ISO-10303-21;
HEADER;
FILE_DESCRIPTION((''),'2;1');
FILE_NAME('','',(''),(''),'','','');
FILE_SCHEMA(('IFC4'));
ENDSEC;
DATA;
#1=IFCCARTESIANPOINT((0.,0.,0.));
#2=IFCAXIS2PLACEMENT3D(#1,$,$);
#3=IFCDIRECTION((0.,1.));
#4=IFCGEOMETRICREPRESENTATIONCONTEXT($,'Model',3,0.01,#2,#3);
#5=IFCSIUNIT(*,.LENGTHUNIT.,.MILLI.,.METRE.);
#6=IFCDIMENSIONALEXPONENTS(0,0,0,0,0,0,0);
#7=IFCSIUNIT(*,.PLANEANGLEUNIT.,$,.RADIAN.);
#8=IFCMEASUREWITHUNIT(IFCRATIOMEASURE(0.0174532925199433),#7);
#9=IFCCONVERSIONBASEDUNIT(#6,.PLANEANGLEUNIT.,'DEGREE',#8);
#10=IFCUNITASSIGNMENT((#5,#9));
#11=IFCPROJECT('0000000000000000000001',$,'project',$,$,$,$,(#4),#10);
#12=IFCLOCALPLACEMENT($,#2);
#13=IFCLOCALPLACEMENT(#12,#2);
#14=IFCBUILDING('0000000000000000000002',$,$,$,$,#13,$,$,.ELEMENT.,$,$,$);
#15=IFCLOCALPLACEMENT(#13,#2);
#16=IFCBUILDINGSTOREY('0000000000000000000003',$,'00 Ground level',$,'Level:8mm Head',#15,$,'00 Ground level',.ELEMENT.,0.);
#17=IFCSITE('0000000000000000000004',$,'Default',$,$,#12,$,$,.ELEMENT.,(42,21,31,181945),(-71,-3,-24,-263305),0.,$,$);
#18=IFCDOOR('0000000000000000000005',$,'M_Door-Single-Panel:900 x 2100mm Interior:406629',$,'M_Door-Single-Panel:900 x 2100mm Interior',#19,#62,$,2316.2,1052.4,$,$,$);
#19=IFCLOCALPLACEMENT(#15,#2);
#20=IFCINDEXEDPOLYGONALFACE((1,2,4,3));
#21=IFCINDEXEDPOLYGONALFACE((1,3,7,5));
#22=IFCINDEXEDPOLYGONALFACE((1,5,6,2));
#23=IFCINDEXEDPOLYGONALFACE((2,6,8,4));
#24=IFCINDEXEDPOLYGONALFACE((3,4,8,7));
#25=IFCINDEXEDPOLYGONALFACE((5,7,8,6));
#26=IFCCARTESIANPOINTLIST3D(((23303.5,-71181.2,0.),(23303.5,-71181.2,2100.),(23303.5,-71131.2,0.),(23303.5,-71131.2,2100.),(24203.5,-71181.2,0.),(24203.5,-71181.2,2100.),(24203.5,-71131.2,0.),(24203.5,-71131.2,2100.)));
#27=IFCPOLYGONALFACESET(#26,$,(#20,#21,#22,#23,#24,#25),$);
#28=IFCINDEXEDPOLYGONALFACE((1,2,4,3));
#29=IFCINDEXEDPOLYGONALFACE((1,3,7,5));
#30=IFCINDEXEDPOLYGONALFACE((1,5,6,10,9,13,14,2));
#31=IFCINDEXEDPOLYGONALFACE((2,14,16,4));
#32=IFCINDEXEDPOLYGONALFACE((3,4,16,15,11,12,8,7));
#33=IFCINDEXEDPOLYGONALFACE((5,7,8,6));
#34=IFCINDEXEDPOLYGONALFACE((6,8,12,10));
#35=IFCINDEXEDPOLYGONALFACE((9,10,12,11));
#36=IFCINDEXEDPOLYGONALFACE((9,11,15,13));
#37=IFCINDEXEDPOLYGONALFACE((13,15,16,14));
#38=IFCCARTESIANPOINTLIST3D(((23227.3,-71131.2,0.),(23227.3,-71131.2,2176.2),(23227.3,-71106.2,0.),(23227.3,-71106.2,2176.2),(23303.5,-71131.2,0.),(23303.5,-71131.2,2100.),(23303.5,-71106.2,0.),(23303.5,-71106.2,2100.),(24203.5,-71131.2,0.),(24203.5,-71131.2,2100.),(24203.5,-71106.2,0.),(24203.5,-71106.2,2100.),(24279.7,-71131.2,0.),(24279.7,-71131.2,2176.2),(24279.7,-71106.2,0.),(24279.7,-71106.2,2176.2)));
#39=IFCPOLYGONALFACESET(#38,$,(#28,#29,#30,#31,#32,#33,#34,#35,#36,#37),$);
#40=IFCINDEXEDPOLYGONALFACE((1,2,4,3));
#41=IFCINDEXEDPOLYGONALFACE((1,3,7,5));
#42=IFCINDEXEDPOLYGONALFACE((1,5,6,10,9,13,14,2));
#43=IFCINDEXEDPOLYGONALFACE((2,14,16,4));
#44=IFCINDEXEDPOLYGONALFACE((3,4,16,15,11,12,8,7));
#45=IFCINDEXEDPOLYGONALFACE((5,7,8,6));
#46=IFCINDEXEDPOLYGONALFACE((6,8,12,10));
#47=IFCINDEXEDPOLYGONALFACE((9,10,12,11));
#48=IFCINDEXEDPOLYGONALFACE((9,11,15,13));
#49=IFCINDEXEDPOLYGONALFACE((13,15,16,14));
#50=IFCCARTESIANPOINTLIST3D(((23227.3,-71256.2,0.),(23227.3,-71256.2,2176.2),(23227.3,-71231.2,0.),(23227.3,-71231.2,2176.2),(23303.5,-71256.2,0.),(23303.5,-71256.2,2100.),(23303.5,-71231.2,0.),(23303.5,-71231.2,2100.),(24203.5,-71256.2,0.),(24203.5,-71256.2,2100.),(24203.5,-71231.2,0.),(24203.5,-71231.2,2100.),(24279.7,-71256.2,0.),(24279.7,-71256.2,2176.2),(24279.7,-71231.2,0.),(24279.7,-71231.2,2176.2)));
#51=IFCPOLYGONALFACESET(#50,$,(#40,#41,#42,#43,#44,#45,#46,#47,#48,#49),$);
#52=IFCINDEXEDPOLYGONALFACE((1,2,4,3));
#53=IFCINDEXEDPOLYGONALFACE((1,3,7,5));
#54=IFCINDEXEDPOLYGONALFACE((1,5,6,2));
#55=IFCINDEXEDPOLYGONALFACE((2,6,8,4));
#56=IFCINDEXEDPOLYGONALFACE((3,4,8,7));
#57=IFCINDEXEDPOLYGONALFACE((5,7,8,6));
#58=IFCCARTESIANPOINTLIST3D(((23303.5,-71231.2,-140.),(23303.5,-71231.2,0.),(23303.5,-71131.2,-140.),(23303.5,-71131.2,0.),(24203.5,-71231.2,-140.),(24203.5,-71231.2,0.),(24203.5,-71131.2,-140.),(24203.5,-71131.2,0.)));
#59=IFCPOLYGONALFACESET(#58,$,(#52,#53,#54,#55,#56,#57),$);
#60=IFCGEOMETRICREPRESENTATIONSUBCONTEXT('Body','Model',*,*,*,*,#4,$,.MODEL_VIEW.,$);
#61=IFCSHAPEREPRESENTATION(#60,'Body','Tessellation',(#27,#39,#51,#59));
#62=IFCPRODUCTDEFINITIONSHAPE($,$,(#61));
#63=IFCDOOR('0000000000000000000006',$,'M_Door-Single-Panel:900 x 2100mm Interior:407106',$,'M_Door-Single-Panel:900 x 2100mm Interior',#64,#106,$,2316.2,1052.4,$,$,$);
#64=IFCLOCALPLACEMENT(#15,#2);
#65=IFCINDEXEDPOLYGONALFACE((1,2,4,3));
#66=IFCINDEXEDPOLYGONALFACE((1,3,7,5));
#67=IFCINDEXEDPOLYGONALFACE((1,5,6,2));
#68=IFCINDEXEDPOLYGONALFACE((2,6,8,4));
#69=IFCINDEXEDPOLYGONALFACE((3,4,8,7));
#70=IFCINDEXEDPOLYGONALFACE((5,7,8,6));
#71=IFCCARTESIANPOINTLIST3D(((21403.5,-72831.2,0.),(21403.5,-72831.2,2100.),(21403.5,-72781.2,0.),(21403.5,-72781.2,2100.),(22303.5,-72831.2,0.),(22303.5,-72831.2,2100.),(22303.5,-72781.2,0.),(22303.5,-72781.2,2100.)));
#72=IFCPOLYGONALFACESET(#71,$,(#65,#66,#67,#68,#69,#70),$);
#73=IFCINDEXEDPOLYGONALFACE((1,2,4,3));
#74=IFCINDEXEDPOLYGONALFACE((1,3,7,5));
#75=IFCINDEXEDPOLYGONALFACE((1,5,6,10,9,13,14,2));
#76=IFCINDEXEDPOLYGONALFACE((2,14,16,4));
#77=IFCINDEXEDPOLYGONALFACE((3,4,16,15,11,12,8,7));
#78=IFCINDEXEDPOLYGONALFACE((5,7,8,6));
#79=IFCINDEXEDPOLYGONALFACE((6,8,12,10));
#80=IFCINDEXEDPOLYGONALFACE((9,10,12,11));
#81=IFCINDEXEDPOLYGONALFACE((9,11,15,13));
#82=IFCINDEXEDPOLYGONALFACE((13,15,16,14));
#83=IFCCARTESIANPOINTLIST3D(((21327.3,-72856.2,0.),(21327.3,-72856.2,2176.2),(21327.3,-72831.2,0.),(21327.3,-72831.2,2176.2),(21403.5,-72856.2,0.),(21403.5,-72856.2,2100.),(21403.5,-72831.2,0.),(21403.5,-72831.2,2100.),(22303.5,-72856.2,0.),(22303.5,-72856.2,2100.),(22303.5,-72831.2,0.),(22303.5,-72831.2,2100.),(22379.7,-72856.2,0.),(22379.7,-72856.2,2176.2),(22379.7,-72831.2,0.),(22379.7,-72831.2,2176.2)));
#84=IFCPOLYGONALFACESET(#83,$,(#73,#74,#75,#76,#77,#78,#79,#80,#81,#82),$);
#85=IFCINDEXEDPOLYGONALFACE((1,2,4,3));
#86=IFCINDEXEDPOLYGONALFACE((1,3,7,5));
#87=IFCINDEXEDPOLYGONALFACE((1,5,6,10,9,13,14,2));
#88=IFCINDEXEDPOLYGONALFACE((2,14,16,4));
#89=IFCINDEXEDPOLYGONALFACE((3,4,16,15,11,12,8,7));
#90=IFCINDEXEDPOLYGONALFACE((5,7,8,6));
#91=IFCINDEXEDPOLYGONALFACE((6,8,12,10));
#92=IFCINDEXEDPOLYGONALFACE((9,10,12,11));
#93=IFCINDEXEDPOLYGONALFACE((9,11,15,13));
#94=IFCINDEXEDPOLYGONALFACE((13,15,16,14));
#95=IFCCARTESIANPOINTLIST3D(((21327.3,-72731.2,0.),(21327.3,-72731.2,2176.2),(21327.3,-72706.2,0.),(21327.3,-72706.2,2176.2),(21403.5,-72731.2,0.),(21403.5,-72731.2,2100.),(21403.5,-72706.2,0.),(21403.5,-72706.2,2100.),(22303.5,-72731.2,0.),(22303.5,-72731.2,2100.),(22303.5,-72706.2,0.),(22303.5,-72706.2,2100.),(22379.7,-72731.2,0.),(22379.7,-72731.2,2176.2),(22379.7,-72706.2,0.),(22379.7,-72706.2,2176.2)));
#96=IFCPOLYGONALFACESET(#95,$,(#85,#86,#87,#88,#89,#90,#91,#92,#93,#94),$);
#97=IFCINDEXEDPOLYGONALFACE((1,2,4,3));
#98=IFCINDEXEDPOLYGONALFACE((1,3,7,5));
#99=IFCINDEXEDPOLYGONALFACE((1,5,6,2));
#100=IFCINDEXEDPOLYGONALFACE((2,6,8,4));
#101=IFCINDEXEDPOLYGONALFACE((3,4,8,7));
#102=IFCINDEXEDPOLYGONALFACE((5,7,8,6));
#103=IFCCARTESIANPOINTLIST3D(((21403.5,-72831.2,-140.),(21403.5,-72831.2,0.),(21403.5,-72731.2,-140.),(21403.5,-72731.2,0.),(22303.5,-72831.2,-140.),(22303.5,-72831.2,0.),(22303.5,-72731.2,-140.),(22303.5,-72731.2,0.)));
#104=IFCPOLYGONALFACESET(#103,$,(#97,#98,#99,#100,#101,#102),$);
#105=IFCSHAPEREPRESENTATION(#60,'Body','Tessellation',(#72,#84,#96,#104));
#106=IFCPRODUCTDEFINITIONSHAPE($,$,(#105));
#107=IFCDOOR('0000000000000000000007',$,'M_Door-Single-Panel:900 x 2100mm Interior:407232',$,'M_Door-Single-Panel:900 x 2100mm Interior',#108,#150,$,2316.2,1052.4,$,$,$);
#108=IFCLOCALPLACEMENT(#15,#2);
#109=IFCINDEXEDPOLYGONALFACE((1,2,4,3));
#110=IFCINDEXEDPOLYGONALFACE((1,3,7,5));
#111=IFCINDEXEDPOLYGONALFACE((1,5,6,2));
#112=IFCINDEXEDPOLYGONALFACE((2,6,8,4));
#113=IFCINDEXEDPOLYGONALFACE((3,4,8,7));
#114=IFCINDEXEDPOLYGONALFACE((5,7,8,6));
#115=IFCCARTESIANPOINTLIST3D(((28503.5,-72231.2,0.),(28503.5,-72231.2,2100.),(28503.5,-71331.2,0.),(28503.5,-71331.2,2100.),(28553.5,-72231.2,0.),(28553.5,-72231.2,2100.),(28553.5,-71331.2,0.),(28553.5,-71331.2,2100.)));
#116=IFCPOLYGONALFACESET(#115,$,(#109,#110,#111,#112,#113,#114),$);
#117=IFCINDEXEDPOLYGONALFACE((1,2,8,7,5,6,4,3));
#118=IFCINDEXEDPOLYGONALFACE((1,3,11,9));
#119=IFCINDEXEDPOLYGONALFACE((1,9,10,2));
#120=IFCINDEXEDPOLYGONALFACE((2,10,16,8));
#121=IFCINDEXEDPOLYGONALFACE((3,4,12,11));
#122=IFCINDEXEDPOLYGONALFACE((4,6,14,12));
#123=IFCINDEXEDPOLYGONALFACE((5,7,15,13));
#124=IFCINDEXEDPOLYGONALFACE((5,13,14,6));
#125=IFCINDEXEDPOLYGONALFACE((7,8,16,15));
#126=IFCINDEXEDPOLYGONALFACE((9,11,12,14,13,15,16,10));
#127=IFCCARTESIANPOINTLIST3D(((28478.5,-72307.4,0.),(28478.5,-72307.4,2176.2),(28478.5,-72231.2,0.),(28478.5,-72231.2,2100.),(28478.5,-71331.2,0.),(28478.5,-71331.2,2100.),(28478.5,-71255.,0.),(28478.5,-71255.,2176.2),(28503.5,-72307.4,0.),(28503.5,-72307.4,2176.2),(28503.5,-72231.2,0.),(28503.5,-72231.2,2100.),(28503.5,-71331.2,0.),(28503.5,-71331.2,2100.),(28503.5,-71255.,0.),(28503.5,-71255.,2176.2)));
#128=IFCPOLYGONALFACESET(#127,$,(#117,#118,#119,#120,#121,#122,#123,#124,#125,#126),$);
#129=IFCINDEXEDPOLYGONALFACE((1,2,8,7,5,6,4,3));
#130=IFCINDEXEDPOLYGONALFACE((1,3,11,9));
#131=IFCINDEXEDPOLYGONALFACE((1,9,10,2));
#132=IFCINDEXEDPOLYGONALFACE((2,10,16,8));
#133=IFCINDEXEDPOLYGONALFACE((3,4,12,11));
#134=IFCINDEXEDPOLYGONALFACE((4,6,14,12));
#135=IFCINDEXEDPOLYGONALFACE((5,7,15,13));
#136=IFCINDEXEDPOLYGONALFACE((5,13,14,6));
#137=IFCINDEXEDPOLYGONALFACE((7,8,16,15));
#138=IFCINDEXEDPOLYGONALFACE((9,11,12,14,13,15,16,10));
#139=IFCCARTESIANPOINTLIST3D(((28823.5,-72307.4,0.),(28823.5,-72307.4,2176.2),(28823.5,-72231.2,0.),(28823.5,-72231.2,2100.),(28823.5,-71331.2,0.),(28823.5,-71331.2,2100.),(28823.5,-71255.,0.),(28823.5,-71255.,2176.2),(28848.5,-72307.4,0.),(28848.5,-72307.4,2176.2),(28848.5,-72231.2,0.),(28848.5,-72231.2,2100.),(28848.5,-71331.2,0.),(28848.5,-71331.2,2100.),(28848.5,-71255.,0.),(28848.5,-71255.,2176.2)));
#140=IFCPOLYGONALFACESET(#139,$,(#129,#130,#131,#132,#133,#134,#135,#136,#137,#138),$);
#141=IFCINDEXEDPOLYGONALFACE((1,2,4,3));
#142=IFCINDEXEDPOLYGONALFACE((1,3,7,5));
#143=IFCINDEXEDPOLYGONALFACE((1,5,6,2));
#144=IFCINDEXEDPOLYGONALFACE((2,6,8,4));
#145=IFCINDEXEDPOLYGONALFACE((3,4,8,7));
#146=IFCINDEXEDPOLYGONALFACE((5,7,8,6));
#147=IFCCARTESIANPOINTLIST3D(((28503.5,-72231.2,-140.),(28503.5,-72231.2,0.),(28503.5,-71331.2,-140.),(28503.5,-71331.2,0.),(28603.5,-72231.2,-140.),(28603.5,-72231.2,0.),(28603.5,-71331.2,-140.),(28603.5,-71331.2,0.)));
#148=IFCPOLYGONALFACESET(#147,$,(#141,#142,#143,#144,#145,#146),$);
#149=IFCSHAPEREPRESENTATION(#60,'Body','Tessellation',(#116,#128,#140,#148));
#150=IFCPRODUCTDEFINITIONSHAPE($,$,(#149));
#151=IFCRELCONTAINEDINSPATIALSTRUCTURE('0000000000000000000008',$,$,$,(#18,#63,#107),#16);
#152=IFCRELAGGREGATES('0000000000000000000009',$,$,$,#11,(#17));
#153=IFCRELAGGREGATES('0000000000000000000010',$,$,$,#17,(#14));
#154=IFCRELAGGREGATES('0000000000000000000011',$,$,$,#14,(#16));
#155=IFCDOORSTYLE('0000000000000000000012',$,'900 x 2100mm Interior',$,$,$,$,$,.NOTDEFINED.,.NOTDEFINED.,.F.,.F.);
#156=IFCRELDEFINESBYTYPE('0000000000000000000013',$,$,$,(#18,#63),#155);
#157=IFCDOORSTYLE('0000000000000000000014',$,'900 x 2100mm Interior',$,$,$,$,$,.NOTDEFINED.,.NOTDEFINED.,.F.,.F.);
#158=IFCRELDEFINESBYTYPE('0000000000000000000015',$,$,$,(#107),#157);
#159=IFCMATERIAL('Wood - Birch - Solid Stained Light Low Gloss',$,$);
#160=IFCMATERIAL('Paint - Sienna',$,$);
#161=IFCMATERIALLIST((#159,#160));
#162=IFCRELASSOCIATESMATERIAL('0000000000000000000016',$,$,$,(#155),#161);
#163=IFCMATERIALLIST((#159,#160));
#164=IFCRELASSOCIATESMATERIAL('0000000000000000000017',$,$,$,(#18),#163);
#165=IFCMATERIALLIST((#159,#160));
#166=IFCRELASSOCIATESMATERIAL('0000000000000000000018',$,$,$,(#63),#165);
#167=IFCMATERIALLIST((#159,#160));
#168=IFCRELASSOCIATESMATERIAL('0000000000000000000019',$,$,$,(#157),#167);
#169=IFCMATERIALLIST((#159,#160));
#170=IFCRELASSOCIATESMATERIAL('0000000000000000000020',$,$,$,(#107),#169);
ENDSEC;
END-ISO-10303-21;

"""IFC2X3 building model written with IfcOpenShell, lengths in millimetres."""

from ifc_helpers import new_model, entity, si_unit, converted_unit, direction, frame, frame_2d, origin, origin_2d_with_axis, place, context, subcontext, project, spatial, polyline, rectangle, outline, extrude, source, transform, mapped, material, material_list, type_object, type_shapes, element, save


model = new_model("IFC2X3")

# Units and contexts
model_context = context("Model", 3, precision=0.01, world=origin(), true_north=direction((0.0, 1.0)))
body_context = subcontext(model_context, "Body", "Model", "MODEL_VIEW")
ifc_project = project(units=[si_unit("LENGTHUNIT", "METRE", prefix="MILLI"), converted_unit("PLANEANGLEUNIT", "DEGREE", entity("IfcRatioMeasure", 0.0174532925199433), si_unit("PLANEANGLEUNIT", "RADIAN"), dimensions=[0, 0, 0, 0, 0, 0, 0])], contexts=[model_context])

# Site, building, storey
site_placement = place(None, origin())
site = spatial("IfcSite", under=ifc_project, at=site_placement, Name="Default", CompositionType="ELEMENT", RefLatitude=(42, 21, 31, 181945), RefLongitude=(-71, -3, -24, -263305), RefElevation=0.0)
building_placement = place(site_placement, origin())
building = spatial("IfcBuilding", under=site, at=building_placement, CompositionType="ELEMENT")
storey_placement = place(building_placement, origin())
storey = spatial("IfcBuildingStorey", under=building, at=storey_placement, Name="00 Ground level", ObjectType="Level:8mm Head", LongName="00 Ground level", CompositionType="ELEMENT", Elevation=0.0)

# Doors
ifc_material_1 = material(Name="Wood - Birch - Solid Stained Light Low Gloss")
ifc_material_2 = material(Name="Paint - Sienna")
ifc_material_list_1 = material_list([ifc_material_1, ifc_material_2])
ifc_material_list_2 = material_list([ifc_material_1, ifc_material_2])
door_style_1 = type_object("IfcDoorStyle", Name="900 x 2100mm Interior", ConstructionType="NOTDEFINED", OperationType="NOTDEFINED", ParameterTakesPrecedence=False, Sizeable=False, material=ifc_material_list_2)
shared_shape_1 = source(origin(), body_context, "Body", "SweptSolid", [
    extrude(rectangle(XDim=50.0, YDim=900.0, at=frame_2d((0.0, 0.0), x_axis=(1.0, 0.0))), frame((450.0, 75.0, 140.0), z_axis=(0.0, 0.0, 1.0), x_axis=(0.0, 1.0, 0.0)), (0.0, 0.0, 1.0), 2100.0),
    extrude(outline(polyline([(-526.2, -1107.2), (526.2, -1107.2), (526.2, 1069.0), (450.0, 1069.0), (450.0, -1031.0), (-450.0, -1031.0), (-450.0, 1069.0), (-526.2, 1069.0), (-526.2, -1107.2)])), frame((450.0, 100.0, 1209.0), z_axis=(0.0, 1.0, 0.0), x_axis=(1.0, 0.0, 0.0)), (0.0, 0.0, 1.0), 25.0),
    extrude(outline(polyline([(-1107.2, -526.2), (1069.0, -526.2), (1069.0, -450.0), (-1031.0, -450.0), (-1031.0, 450.0), (1069.0, 450.0), (1069.0, 526.2), (-1107.2, 526.2), (-1107.2, -526.2)])), frame((450.0, -25.0, 1209.0), z_axis=(0.0, 1.0, 0.0), x_axis=(0.0, 0.0, -1.0)), (0.0, 0.0, 1.0), 25.0),
    extrude(rectangle(XDim=900.0, YDim=100.0, at=origin_2d_with_axis()), frame((450.0, 50.0, 0.0), z_axis=(0.0, 0.0, 1.0), x_axis=(-1.0, 0.0, 0.0)), (0.0, 0.0, 1.0), 140.0),
])
type_shapes(door_style_1, [shared_shape_1])
door_1_placement = place(storey_placement, frame((23303.5, -71231.2, -140.0)))
element("IfcDoor", 1, at=door_1_placement, inside=storey, type_object=door_style_1, material=ifc_material_list_1, Name="M_Door-Single-Panel:900 x 2100mm Interior:406629", ObjectType="M_Door-Single-Panel:900 x 2100mm Interior", OverallHeight=2316.2, OverallWidth=1052.4, context=body_context, shape_type="MappedRepresentation", body=[
    mapped(shared_shape_1, transform((0.0, 0.0, 0.0), scale=1.0)),
])
ifc_material_list_3 = material_list([ifc_material_1, ifc_material_2])
door_2_placement = place(storey_placement, frame((22303.5, -72731.2, -140.0), z_axis=(0.0, 0.0, 1.0), x_axis=(-1.0, 0.0, 0.0)))
element("IfcDoor", 2, at=door_2_placement, inside=storey, type_object=door_style_1, material=ifc_material_list_3, Name="M_Door-Single-Panel:900 x 2100mm Interior:407106", ObjectType="M_Door-Single-Panel:900 x 2100mm Interior", OverallHeight=2316.2, OverallWidth=1052.4, context=body_context, shape_type="MappedRepresentation", body=[
    mapped(shared_shape_1, transform((0.0, 0.0, 0.0), scale=1.0)),
])
ifc_material_list_4 = material_list([ifc_material_1, ifc_material_2])
ifc_material_list_5 = material_list([ifc_material_1, ifc_material_2])
door_style_2 = type_object("IfcDoorStyle", Name="900 x 2100mm Interior", ConstructionType="NOTDEFINED", OperationType="NOTDEFINED", ParameterTakesPrecedence=False, Sizeable=False, material=ifc_material_list_5)
shared_shape_2 = source(origin(), body_context, "Body", "SweptSolid", [
    extrude(rectangle(XDim=50.0, YDim=900.0, at=origin_2d_with_axis()), frame((450.0, 295.0, 140.0), z_axis=(0.0, 0.0, 1.0), x_axis=(0.0, 1.0, 0.0)), (0.0, 0.0, 1.0), 2100.0),
    extrude(outline(polyline([(-526.2, -1107.2), (526.2, -1107.2), (526.2, 1069.0), (450.0, 1069.0), (450.0, -1031.0), (-450.0, -1031.0), (-450.0, 1069.0), (-526.2, 1069.0), (-526.2, -1107.2)])), frame((450.0, 320.0, 1209.0), z_axis=(0.0, 1.0, 0.0), x_axis=(1.0, 0.0, 0.0)), (0.0, 0.0, 1.0), 25.0),
    extrude(outline(polyline([(-1107.2, -526.2), (1069.0, -526.2), (1069.0, -450.0), (-1031.0, -450.0), (-1031.0, 450.0), (1069.0, 450.0), (1069.0, 526.2), (-1107.2, 526.2), (-1107.2, -526.2)])), frame((450.0, -25.0, 1209.0), z_axis=(0.0, 1.0, 0.0), x_axis=(0.0, 0.0, -1.0)), (0.0, 0.0, 1.0), 25.0),
    extrude(rectangle(XDim=900.0, YDim=100.0, at=frame_2d((0.0, 0.0), x_axis=(1.0, 0.0))), frame((450.0, 270.0, 0.0), z_axis=(0.0, 0.0, 1.0), x_axis=(-1.0, 0.0, 0.0)), (0.0, 0.0, 1.0), 140.0),
])
type_shapes(door_style_2, [shared_shape_2])
door_3_placement = place(storey_placement, frame((28823.5, -72231.2, -140.0), z_axis=(0.0, 0.0, 1.0), x_axis=(0.0, 1.0, 0.0)))
element("IfcDoor", 3, at=door_3_placement, inside=storey, type_object=door_style_2, material=ifc_material_list_4, Name="M_Door-Single-Panel:900 x 2100mm Interior:407232", ObjectType="M_Door-Single-Panel:900 x 2100mm Interior", OverallHeight=2316.2, OverallWidth=1052.4, context=body_context, shape_type="MappedRepresentation", body=[
    mapped(shared_shape_2, transform((0.0, 0.0, 0.0), scale=1.0)),
])

save(model, "model.ifc")
